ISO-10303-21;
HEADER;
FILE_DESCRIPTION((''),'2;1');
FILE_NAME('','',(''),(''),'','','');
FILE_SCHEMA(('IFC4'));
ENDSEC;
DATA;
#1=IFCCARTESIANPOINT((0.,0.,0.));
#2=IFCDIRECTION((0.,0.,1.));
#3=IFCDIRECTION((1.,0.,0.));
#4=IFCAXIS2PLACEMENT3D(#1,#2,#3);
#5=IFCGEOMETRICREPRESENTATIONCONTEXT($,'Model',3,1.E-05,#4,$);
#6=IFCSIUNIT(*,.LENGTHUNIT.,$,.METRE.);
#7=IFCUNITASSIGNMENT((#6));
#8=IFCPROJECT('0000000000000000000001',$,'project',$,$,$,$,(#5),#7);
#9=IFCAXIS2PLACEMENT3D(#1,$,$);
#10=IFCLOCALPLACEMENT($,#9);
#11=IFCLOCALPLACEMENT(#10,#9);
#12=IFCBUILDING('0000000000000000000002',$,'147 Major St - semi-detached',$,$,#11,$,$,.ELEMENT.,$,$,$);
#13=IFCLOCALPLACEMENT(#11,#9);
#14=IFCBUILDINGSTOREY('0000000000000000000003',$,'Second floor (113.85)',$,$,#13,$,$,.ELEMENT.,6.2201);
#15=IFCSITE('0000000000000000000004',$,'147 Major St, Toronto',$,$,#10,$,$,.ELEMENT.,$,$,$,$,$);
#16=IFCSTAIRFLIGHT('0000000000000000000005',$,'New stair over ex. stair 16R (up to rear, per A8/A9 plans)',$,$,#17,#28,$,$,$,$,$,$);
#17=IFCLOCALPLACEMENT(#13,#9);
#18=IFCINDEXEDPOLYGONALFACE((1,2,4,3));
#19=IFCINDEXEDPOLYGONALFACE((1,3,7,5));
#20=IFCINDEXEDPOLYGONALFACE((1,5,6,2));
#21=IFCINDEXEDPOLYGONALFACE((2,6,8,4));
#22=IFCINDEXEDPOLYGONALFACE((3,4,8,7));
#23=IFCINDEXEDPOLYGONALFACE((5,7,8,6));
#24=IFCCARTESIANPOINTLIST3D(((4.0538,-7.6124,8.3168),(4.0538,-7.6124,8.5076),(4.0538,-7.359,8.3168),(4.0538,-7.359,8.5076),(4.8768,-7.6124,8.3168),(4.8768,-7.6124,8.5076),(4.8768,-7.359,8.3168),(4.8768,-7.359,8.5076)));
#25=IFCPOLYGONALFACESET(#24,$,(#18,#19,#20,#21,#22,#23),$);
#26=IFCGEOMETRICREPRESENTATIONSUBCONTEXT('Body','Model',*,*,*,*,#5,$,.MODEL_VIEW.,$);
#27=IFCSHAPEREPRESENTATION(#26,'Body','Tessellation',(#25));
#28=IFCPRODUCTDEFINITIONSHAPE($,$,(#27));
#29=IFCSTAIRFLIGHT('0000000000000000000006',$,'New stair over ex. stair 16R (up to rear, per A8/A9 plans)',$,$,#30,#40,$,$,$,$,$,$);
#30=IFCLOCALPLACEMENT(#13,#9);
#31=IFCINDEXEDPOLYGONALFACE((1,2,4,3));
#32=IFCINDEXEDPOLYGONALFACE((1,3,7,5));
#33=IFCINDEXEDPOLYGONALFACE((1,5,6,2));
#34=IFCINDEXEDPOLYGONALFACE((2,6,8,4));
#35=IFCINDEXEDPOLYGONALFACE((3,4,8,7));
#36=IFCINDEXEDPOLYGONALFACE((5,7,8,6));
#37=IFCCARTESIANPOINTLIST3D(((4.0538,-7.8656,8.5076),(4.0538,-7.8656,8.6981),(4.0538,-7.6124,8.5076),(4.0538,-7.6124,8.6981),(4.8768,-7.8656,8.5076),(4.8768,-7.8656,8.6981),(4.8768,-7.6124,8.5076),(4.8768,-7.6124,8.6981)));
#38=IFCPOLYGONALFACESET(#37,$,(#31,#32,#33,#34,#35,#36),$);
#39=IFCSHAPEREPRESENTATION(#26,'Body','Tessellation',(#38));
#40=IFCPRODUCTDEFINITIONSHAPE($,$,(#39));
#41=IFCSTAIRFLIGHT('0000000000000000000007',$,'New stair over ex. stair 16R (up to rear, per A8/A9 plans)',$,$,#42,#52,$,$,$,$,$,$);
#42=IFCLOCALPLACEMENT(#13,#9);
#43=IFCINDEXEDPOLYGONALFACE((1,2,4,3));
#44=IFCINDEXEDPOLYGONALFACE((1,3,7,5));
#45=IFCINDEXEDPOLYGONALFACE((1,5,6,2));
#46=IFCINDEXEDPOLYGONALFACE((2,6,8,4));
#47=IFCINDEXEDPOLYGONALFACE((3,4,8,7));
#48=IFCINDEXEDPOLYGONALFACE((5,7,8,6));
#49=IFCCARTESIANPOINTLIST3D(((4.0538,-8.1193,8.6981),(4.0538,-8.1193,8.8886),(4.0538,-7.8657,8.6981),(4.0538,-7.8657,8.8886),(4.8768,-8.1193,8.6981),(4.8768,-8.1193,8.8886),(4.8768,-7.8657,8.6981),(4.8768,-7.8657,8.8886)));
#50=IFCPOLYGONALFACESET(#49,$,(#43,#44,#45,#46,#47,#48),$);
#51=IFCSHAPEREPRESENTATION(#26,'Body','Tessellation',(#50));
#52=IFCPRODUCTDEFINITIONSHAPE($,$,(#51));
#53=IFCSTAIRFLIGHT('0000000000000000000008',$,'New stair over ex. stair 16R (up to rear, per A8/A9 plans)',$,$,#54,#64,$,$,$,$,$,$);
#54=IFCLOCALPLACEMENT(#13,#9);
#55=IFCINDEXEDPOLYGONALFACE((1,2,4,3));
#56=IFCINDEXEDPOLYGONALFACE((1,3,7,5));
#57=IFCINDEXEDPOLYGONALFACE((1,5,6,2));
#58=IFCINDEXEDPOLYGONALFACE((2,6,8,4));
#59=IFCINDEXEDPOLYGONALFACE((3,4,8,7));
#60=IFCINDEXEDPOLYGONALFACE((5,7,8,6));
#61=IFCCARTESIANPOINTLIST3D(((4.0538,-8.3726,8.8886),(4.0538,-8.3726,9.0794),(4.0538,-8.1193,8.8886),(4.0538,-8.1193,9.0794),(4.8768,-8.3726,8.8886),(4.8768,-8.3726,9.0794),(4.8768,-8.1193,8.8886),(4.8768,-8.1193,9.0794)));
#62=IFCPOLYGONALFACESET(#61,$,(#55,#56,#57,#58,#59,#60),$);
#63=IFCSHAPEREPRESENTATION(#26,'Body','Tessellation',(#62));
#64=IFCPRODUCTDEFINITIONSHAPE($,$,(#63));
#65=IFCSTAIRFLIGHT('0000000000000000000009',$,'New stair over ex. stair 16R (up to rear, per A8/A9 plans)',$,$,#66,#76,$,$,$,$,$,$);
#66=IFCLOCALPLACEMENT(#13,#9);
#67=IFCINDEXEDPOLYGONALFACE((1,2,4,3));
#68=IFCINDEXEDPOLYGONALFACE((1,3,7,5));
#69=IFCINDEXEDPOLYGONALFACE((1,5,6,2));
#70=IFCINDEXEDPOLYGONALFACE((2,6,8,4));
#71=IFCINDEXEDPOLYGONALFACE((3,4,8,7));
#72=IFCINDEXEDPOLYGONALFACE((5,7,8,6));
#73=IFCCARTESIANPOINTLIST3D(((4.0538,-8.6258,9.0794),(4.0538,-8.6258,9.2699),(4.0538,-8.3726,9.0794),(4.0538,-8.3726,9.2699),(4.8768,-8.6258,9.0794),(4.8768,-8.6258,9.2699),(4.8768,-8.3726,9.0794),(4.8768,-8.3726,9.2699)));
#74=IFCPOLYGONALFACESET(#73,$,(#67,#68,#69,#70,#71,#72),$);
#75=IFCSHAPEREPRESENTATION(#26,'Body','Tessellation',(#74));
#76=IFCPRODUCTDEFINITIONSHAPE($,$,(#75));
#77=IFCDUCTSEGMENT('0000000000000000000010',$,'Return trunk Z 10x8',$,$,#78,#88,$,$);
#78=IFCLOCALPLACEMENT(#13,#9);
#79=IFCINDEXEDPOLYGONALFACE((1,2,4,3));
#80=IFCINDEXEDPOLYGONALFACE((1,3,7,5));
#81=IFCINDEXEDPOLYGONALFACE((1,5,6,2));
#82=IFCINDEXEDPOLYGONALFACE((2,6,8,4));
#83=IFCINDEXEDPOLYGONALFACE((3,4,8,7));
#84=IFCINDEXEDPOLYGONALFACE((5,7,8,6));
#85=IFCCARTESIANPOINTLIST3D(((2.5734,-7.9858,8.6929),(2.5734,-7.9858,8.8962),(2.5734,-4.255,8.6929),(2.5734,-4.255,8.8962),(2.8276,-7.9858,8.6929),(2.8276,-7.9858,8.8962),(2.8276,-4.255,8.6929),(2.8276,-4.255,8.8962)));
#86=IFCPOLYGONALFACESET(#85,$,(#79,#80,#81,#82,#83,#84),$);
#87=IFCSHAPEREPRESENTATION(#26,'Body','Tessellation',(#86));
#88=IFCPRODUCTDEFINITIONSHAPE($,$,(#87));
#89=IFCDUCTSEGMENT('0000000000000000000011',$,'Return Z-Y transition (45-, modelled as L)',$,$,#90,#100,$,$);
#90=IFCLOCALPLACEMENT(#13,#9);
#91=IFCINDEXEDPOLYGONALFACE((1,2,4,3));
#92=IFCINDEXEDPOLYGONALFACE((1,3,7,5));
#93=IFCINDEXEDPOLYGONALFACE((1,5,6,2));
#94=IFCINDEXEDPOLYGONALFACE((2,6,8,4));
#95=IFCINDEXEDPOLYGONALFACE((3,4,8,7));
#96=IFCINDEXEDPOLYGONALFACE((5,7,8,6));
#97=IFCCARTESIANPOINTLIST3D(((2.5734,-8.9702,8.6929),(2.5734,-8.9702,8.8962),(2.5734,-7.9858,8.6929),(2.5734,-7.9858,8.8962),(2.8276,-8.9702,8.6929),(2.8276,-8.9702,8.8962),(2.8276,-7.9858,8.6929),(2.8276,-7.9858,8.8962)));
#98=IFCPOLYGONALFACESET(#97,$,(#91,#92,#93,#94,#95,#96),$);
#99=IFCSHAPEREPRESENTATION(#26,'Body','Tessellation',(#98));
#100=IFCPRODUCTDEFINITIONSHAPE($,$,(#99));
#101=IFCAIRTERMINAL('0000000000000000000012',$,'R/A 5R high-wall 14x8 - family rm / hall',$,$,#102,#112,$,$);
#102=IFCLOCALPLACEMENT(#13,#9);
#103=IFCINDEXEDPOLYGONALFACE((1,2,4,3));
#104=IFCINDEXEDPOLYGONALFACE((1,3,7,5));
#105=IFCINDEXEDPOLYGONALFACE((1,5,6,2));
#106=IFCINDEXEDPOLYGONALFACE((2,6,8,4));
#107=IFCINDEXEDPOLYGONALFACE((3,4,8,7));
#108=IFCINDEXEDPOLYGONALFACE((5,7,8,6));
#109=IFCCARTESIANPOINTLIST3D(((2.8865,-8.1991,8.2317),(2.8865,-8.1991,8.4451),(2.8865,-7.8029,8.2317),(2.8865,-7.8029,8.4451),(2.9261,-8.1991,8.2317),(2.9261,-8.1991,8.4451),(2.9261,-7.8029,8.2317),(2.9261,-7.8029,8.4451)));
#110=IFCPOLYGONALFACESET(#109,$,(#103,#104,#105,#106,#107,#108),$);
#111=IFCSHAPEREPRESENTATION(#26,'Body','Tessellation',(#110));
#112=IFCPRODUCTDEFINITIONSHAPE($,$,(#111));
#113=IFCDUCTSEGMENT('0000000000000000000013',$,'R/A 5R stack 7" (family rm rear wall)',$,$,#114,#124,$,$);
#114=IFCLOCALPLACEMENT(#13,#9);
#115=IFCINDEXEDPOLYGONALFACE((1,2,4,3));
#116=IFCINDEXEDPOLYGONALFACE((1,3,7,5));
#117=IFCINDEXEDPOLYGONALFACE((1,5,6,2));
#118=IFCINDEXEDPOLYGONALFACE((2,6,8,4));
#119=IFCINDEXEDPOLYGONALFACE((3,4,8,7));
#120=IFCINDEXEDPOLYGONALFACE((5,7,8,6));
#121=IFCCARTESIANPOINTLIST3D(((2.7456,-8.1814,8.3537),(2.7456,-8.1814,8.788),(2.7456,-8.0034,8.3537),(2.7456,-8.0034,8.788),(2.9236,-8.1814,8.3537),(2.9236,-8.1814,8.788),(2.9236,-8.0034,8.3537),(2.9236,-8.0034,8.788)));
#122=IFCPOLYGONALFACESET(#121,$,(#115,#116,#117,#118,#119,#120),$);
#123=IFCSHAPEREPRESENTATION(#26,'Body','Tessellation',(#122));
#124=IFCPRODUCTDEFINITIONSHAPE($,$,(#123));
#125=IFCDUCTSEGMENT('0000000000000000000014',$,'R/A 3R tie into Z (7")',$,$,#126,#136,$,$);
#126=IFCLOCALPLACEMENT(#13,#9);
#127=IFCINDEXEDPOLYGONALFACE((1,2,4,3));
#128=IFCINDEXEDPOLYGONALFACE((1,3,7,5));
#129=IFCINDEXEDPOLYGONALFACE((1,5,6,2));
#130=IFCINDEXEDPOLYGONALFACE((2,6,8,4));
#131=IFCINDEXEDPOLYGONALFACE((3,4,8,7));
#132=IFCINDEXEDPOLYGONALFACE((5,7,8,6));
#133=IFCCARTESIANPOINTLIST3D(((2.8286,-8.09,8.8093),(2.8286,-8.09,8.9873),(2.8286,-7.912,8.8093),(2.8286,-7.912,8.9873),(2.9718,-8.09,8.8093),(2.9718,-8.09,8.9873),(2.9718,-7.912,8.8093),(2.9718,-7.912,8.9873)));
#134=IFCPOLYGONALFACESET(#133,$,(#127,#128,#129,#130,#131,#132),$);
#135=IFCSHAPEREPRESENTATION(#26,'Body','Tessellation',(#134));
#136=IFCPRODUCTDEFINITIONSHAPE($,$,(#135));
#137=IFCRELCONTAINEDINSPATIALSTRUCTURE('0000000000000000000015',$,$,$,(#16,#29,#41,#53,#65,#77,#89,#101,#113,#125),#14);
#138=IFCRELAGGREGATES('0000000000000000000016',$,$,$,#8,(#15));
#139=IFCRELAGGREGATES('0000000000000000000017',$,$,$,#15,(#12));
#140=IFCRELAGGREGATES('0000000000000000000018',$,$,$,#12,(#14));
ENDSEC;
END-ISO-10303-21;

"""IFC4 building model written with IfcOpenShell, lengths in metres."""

from ifc_helpers import new_model, si_unit, frame, origin, origin_with_axes, place, context, subcontext, project, spatial, rectangle, extrude, element, save


model = new_model("IFC4")

# Units and contexts
model_context = context("Model", 3, precision=1e-05, world=origin_with_axes())
body_context = subcontext(model_context, "Body", "Model", "MODEL_VIEW")
ifc_project = project(units=[si_unit("LENGTHUNIT", "METRE")], contexts=[model_context])

# Site, building, storey
site_placement = place(None, origin())
site = spatial("IfcSite", under=ifc_project, at=site_placement, Name="147 Major St, Toronto", CompositionType="ELEMENT")
building_placement = place(site_placement, origin())
building = spatial("IfcBuilding", under=site, at=building_placement, Name="147 Major St - semi-detached", CompositionType="ELEMENT")
storey_placement = place(building_placement, origin())
storey = spatial("IfcBuildingStorey", under=building, at=storey_placement, Name="Second floor (113.85)", CompositionType="ELEMENT", Elevation=6.2201)

# Stair flights
stair_flight_1_placement = place(storey_placement, frame((4.4653, -7.4857, 8.3168)))
element("IfcStairFlight", 1, at=stair_flight_1_placement, inside=storey, Name="New stair over ex. stair 16R (up to rear, per A8/A9 plans)", context=body_context, shape_type="SweptSolid", body=[
    extrude(rectangle(XDim=0.823, YDim=0.2533), origin_with_axes(), (0.0, 0.0, 1.0), 0.1908),
])
stair_flight_2_placement = place(storey_placement, frame((4.4653, -7.739, 8.5076)))
element("IfcStairFlight", 2, at=stair_flight_2_placement, inside=storey, Name="New stair over ex. stair 16R (up to rear, per A8/A9 plans)", context=body_context, shape_type="SweptSolid", body=[
    extrude(rectangle(XDim=0.823, YDim=0.2533), origin_with_axes(), (0.0, 0.0, 1.0), 0.1905),
])
stair_flight_3_placement = place(storey_placement, frame((4.4653, -7.9925, 8.6981)))
element("IfcStairFlight", 3, at=stair_flight_3_placement, inside=storey, Name="New stair over ex. stair 16R (up to rear, per A8/A9 plans)", context=body_context, shape_type="SweptSolid", body=[
    extrude(rectangle(XDim=0.823, YDim=0.2536), origin_with_axes(), (0.0, 0.0, 1.0), 0.1905),
])
stair_flight_4_placement = place(storey_placement, frame((4.4653, -8.2459, 8.8886)))
element("IfcStairFlight", 4, at=stair_flight_4_placement, inside=storey, Name="New stair over ex. stair 16R (up to rear, per A8/A9 plans)", context=body_context, shape_type="SweptSolid", body=[
    extrude(rectangle(XDim=0.823, YDim=0.2533), origin_with_axes(), (0.0, 0.0, 1.0), 0.1908),
])
stair_flight_5_placement = place(storey_placement, frame((4.4653, -8.4992, 9.0794)))
element("IfcStairFlight", 5, at=stair_flight_5_placement, inside=storey, Name="New stair over ex. stair 16R (up to rear, per A8/A9 plans)", context=body_context, shape_type="SweptSolid", body=[
    extrude(rectangle(XDim=0.823, YDim=0.2533), origin_with_axes(), (0.0, 0.0, 1.0), 0.1905),
])

# Duct segments
duct_segment_1_placement = place(storey_placement, frame((2.7005, -6.1204, 8.6929)))
element("IfcDuctSegment", 6, at=duct_segment_1_placement, inside=storey, Name="Return trunk Z 10x8", context=body_context, shape_type="SweptSolid", body=[
    extrude(rectangle(XDim=0.2542, YDim=3.7308), origin_with_axes(), (0.0, 0.0, 1.0), 0.2033),
])
duct_segment_2_placement = place(storey_placement, frame((2.7005, -8.478, 8.6929)))
element("IfcDuctSegment", 7, at=duct_segment_2_placement, inside=storey, Name="Return Z-Y transition (45-, modelled as L)", context=body_context, shape_type="SweptSolid", body=[
    extrude(rectangle(XDim=0.2542, YDim=0.9845), origin_with_axes(), (0.0, 0.0, 1.0), 0.2033),
])

# Air terminal
air_terminal_placement = place(storey_placement, frame((2.9063, -8.001, 8.2317)))
element("IfcAirTerminal", 8, at=air_terminal_placement, inside=storey, Name="R/A 5R high-wall 14x8 - family rm / hall", context=body_context, shape_type="SweptSolid", body=[
    extrude(rectangle(XDim=0.0396, YDim=0.3962), origin_with_axes(), (0.0, 0.0, 1.0), 0.2134),
])

# Duct segments
duct_segment_3_placement = place(storey_placement, frame((2.8346, -8.0924, 8.3537)))
element("IfcDuctSegment", 9, at=duct_segment_3_placement, inside=storey, Name="R/A 5R stack 7\" (family rm rear wall)", context=body_context, shape_type="SweptSolid", body=[
    extrude(rectangle(XDim=0.178, YDim=0.178), origin_with_axes(), (0.0, 0.0, 1.0), 0.4343),
])
duct_segment_4_placement = place(storey_placement, frame((2.9002, -8.001, 8.8093)))
element("IfcDuctSegment", 10, at=duct_segment_4_placement, inside=storey, Name="R/A 3R tie into Z (7\")", context=body_context, shape_type="SweptSolid", body=[
    extrude(rectangle(XDim=0.1433, YDim=0.178), origin_with_axes(), (0.0, 0.0, 1.0), 0.178),
])

save(model, "model.ifc")
